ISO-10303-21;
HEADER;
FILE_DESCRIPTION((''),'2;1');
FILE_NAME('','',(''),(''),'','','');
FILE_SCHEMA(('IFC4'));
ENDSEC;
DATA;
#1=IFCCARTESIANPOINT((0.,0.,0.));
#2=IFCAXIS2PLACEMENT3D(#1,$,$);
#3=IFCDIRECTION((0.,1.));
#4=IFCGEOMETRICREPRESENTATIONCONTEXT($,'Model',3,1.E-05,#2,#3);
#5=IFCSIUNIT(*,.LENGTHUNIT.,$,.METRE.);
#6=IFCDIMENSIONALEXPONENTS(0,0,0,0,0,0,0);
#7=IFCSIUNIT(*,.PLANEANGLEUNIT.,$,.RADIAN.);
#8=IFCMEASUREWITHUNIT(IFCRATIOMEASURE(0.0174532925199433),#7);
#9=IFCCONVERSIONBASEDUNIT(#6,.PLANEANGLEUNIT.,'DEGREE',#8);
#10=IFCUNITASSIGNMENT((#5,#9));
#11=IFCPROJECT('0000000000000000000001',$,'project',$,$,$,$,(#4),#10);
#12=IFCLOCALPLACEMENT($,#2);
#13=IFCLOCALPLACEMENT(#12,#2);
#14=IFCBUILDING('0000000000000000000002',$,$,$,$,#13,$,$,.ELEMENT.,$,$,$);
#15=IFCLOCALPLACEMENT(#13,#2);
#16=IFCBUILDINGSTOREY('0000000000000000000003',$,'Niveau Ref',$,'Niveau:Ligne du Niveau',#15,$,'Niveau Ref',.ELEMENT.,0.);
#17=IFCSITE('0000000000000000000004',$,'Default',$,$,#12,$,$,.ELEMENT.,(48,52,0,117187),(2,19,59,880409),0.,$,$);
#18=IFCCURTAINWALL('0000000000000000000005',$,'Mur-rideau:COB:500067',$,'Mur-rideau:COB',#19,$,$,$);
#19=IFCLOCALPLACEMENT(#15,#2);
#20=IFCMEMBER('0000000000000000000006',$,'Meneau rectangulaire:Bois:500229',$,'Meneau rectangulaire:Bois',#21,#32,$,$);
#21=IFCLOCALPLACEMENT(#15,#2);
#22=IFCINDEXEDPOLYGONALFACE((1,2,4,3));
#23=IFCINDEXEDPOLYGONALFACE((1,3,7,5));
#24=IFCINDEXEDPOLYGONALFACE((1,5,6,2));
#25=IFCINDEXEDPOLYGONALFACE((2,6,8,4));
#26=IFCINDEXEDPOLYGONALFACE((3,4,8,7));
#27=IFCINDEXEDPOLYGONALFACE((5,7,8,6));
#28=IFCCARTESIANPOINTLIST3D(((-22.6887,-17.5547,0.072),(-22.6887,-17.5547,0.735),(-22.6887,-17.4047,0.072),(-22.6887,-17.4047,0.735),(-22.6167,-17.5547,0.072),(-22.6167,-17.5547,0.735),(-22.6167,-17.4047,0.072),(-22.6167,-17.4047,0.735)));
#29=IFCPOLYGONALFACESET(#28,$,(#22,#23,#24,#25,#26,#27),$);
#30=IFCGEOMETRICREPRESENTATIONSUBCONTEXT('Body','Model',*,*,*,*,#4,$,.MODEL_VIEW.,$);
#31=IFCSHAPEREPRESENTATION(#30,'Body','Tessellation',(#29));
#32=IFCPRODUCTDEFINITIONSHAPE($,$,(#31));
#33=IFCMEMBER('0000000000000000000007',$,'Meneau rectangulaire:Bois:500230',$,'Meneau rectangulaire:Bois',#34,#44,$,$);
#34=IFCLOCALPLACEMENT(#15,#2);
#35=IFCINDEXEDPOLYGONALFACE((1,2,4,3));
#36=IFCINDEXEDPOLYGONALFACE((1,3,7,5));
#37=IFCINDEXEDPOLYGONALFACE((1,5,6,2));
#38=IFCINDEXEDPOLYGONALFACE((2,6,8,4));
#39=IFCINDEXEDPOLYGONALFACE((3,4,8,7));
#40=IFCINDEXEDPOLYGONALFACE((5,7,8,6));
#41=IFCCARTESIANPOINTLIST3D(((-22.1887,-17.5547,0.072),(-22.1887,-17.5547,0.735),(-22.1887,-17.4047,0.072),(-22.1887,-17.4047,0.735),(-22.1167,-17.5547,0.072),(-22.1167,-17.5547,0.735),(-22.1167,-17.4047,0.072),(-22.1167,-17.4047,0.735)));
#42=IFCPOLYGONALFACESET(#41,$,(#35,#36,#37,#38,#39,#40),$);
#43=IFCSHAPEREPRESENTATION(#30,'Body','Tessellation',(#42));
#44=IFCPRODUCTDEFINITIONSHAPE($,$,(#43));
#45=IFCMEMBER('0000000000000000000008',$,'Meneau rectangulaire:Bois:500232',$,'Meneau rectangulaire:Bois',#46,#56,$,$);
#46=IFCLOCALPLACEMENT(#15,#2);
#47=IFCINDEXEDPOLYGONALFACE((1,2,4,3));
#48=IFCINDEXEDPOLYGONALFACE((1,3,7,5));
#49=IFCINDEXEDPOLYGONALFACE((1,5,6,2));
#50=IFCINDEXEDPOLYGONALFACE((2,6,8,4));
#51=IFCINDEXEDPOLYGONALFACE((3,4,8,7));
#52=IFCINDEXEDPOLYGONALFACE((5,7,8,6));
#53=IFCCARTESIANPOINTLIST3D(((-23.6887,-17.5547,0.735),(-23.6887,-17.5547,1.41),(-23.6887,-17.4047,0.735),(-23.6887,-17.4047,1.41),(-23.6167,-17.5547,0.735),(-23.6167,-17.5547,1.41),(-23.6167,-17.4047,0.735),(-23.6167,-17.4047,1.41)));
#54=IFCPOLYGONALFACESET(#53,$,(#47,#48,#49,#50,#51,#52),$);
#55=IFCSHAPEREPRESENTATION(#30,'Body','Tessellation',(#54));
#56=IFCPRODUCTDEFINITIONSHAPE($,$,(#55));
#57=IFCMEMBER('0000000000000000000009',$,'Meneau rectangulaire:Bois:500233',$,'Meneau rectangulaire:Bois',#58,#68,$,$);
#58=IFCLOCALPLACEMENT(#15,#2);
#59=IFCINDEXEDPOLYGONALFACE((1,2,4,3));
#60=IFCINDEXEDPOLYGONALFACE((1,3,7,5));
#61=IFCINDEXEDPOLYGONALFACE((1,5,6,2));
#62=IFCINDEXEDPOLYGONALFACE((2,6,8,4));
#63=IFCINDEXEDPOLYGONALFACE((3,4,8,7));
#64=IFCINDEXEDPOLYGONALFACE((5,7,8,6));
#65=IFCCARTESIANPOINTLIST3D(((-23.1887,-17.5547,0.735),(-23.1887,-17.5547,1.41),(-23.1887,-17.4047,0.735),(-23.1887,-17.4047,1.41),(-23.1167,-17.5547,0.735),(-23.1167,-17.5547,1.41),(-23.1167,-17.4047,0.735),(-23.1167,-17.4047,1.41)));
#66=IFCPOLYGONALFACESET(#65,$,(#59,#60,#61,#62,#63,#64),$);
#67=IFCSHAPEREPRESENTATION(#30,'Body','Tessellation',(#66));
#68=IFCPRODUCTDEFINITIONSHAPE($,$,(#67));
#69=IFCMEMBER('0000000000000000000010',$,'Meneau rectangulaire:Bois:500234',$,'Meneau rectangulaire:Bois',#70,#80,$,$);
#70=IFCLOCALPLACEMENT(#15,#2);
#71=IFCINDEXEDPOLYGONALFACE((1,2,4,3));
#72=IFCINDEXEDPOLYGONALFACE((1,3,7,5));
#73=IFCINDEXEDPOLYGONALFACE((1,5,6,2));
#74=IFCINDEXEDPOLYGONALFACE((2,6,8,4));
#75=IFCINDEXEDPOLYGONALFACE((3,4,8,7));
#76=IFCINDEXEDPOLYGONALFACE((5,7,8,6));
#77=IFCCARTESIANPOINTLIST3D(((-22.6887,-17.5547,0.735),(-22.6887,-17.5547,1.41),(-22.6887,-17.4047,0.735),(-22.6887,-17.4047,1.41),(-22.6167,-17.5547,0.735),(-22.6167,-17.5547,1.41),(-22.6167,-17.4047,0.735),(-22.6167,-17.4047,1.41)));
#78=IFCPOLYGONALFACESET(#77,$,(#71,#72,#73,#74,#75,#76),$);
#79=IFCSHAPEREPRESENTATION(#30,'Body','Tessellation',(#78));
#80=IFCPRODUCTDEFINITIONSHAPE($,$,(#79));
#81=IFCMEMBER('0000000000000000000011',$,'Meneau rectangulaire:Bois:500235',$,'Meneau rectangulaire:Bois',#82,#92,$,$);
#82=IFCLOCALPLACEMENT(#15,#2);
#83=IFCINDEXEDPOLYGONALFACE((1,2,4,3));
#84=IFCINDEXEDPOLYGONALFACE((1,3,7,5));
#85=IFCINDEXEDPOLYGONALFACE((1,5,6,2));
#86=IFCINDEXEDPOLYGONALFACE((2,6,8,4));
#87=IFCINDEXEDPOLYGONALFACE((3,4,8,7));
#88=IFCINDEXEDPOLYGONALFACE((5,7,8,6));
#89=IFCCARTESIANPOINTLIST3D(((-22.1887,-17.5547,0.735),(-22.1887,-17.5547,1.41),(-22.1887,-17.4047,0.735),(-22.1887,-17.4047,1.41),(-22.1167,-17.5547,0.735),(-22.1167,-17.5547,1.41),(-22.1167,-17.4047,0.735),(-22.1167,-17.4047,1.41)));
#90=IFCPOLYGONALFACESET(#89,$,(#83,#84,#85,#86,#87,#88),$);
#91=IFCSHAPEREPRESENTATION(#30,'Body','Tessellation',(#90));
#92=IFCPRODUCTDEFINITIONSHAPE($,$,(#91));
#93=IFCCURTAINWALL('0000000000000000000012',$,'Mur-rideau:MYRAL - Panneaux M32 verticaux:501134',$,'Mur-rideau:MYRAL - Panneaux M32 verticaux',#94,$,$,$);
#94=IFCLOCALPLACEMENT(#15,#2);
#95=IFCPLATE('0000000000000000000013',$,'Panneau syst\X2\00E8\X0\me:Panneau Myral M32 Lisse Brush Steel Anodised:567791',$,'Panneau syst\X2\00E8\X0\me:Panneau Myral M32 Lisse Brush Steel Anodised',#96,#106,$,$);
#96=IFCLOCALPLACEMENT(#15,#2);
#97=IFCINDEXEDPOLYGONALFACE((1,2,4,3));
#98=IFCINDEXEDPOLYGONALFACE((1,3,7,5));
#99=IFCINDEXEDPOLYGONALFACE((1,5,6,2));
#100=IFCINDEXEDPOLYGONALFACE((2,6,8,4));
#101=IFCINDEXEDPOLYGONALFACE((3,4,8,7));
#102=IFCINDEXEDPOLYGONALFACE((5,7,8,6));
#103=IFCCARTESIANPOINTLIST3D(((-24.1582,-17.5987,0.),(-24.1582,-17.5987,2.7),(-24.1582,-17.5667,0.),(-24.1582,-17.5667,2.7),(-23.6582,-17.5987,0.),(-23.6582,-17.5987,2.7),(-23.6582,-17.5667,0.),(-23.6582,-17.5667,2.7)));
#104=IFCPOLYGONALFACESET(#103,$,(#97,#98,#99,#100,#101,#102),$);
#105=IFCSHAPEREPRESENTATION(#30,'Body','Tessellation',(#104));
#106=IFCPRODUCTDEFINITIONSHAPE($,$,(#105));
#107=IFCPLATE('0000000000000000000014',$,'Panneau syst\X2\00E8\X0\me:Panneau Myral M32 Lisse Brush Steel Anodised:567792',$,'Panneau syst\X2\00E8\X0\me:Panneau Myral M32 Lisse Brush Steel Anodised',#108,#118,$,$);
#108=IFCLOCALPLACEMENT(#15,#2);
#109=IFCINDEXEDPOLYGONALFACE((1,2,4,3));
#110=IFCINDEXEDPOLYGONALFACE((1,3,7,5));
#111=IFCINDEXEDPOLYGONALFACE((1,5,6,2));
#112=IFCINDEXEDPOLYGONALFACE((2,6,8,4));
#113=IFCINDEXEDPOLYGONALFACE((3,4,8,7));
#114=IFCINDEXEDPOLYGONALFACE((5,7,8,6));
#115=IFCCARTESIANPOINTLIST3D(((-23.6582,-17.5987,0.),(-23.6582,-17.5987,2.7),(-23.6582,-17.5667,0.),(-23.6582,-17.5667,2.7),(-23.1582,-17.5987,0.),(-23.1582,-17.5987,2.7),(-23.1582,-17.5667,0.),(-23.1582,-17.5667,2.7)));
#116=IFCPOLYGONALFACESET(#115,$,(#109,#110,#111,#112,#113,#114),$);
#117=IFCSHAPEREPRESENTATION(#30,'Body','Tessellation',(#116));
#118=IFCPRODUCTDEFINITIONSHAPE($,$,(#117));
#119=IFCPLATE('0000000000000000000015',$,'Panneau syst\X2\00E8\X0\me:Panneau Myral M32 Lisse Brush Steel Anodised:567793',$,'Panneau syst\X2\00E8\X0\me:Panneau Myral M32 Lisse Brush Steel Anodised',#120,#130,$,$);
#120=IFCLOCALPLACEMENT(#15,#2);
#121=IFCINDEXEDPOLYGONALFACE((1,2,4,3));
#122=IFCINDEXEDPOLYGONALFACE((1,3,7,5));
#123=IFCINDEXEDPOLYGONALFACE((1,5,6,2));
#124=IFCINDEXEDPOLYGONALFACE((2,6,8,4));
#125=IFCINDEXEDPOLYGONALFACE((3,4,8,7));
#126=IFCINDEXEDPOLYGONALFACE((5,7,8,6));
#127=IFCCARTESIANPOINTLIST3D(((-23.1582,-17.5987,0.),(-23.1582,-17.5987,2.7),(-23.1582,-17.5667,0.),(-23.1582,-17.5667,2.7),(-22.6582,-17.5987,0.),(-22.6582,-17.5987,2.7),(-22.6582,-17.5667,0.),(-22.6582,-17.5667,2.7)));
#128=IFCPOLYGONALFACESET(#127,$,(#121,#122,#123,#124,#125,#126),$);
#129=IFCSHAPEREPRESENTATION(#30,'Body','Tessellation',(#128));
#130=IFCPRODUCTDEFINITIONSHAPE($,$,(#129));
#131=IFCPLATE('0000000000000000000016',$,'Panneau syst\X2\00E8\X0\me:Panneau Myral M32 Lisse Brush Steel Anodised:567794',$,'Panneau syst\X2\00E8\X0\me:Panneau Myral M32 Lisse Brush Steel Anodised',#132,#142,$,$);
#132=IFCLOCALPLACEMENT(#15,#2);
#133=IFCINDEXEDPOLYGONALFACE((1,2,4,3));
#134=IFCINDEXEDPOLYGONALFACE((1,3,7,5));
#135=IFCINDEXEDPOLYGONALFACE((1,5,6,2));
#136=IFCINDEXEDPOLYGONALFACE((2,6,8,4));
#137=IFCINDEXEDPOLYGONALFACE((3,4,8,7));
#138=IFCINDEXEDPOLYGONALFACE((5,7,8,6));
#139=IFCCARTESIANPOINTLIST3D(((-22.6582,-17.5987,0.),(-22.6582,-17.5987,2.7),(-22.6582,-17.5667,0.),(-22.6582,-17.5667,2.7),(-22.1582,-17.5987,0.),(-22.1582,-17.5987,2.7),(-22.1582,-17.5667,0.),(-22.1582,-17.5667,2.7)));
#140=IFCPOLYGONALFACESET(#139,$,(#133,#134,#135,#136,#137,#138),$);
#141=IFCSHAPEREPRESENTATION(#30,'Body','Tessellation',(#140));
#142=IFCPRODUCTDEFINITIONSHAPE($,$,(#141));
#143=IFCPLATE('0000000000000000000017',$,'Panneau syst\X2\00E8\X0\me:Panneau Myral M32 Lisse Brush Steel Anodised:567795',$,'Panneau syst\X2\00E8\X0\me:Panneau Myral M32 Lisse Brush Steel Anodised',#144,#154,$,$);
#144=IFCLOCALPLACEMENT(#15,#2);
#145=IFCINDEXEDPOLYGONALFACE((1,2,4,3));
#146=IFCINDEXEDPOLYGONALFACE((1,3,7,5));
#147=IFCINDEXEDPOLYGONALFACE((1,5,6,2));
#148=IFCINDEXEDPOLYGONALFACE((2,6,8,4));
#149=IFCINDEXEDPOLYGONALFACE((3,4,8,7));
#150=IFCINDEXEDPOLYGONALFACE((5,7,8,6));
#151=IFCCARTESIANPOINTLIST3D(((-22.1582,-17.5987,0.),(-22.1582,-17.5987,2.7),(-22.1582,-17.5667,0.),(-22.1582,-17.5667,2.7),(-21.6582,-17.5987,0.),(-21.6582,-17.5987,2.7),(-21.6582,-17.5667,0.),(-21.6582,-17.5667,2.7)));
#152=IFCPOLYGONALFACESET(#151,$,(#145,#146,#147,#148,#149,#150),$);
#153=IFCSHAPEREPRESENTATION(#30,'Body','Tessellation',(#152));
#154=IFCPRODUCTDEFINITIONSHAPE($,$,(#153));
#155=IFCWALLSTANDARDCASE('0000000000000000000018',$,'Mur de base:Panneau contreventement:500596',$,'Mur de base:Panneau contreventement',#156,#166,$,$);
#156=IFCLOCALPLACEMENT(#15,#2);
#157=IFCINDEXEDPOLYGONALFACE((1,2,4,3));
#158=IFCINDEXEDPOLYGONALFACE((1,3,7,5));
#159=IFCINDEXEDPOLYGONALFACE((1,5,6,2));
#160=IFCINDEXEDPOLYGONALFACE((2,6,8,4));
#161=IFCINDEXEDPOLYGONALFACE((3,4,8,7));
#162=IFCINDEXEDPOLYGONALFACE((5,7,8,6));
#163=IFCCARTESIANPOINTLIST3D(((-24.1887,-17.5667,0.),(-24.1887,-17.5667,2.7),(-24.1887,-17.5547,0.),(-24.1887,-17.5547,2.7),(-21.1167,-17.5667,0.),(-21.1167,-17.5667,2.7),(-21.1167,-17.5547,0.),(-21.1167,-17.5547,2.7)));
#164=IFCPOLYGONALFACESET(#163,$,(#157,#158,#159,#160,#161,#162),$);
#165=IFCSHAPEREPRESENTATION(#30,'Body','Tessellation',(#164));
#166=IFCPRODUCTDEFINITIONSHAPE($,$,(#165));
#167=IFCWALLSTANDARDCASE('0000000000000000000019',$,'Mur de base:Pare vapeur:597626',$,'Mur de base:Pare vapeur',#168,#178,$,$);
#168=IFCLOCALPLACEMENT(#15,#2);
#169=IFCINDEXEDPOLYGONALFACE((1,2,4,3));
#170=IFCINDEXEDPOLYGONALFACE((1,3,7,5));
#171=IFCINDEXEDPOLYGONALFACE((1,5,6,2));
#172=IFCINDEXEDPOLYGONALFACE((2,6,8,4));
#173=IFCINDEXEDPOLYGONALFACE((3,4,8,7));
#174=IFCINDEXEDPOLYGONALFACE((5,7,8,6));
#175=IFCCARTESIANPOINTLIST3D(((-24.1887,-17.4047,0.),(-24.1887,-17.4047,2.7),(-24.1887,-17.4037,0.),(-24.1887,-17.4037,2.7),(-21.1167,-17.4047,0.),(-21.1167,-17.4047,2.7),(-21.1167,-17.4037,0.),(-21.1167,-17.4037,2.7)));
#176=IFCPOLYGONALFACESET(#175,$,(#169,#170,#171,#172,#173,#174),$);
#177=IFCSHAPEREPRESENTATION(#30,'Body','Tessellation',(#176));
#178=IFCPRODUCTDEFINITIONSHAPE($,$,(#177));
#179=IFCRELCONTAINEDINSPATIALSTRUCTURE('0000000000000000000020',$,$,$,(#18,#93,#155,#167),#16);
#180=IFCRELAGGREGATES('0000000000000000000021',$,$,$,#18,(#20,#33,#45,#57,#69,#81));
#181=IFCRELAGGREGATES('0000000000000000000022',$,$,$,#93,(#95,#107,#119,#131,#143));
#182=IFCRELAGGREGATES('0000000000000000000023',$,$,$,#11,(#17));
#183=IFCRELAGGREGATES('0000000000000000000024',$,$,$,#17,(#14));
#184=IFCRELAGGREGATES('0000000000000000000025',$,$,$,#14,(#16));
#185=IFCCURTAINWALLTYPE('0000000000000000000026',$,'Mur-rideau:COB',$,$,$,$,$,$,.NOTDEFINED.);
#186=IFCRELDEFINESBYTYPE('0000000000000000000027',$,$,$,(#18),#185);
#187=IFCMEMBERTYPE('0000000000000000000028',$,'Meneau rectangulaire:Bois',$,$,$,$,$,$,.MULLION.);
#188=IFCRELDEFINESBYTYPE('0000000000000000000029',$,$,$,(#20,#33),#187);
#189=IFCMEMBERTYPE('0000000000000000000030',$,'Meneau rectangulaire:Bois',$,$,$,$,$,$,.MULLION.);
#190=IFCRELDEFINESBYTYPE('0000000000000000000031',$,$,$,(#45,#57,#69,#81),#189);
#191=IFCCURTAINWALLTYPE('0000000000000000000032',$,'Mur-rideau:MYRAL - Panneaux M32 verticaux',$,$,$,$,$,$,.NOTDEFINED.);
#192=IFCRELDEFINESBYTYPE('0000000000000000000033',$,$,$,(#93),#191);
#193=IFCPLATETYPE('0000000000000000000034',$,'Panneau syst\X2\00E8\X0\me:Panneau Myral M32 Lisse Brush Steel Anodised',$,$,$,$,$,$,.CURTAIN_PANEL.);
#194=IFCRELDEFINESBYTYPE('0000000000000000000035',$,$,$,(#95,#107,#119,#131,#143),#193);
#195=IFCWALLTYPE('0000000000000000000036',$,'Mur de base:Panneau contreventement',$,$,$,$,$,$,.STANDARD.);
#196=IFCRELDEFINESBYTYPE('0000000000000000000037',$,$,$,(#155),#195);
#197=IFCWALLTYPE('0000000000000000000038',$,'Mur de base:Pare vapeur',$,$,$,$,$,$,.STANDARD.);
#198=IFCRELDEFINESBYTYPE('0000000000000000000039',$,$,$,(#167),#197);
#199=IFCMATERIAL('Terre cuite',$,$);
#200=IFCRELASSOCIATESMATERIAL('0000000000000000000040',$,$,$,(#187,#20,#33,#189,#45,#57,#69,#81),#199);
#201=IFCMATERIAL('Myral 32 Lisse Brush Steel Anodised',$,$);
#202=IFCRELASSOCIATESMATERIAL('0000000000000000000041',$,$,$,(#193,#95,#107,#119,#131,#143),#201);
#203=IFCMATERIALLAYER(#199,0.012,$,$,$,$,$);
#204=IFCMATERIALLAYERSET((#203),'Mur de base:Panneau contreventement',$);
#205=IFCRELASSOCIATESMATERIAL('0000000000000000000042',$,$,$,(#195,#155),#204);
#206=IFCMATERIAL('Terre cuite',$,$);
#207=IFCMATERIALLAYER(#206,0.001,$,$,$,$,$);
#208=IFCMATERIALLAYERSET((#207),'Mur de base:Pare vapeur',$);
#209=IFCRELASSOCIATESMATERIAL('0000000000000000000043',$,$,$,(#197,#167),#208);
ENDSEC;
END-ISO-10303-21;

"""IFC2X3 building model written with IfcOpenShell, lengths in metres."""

from ifc_helpers import new_model, entity, si_unit, converted_unit, direction, frame, frame_2d, origin, origin_2d_with_axis, place, context, subcontext, project, spatial, rectangle, extrude, source, transform, mapped, material, layer, layer_set, layer_usage, type_object, type_shapes, element, aggregate, save


model = new_model("IFC2X3")

# Units and contexts
model_context = context("Model", 3, precision=1e-05, world=origin(), true_north=direction((0.0, 1.0)))
body_context = subcontext(model_context, "Body", "Model", "MODEL_VIEW")
ifc_project = project(units=[si_unit("LENGTHUNIT", "METRE"), converted_unit("PLANEANGLEUNIT", "DEGREE", entity("IfcRatioMeasure", 0.0174532925199433), si_unit("PLANEANGLEUNIT", "RADIAN"), dimensions=[0, 0, 0, 0, 0, 0, 0])], contexts=[model_context])

# Site, building, storey
site_placement = place(None, origin())
site = spatial("IfcSite", under=ifc_project, at=site_placement, Name="Default", CompositionType="ELEMENT", RefLatitude=(48, 52, 0, 117187), RefLongitude=(2, 19, 59, 880409), RefElevation=0.0)
building_placement = place(site_placement, origin())
building = spatial("IfcBuilding", under=site, at=building_placement, CompositionType="ELEMENT")
storey_placement = place(building_placement, origin())
storey = spatial("IfcBuildingStorey", under=building, at=storey_placement, Name="Niveau Ref", ObjectType="Niveau:Ligne du Niveau", LongName="Niveau Ref", CompositionType="ELEMENT", Elevation=0.0)

# Curtain wall, members
curtain_wall_type_1 = type_object("IfcCurtainWallType", Name="Mur-rideau:COB", PredefinedType="NOTDEFINED")
curtain_wall_1_placement = place(storey_placement, origin())
curtain_wall_1 = element("IfcCurtainWall", 1, at=curtain_wall_1_placement, inside=storey, type_object=curtain_wall_type_1, Name="Mur-rideau:COB:500067", ObjectType="Mur-rideau:COB")
ifc_material_1 = material(Name="Terre cuite")
member_type_1 = type_object("IfcMemberType", Name="Meneau rectangulaire:Bois", PredefinedType="MULLION", material=ifc_material_1)
shared_shape_1 = source(origin(), body_context, "Body", "SweptSolid", [
    extrude(rectangle(XDim=0.15, YDim=0.072, at=origin_2d_with_axis()), frame((-0.024, 0.0, -0.663), z_axis=(0.0, 0.0, 1.0), x_axis=(0.0, -1.0, 0.0)), (0.0, 0.0, 1.0), 0.663),
])
type_shapes(member_type_1, [shared_shape_1])
member_1_placement = place(storey_placement, frame((-22.6287, -17.4797, 0.072), z_axis=(0.0, 0.0, -1.0), x_axis=(1.0, 0.0, 0.0)))
member_1 = element("IfcMember", 2, at=member_1_placement, type_object=member_type_1, material=ifc_material_1, Name="Meneau rectangulaire:Bois:500229", ObjectType="Meneau rectangulaire:Bois", context=body_context, shape_type="MappedRepresentation", body=[
    mapped(shared_shape_1, transform((0.0, 0.0, 0.0), scale=1.0)),
])
member_2_placement = place(storey_placement, frame((-22.1287, -17.4797, 0.072), z_axis=(0.0, 0.0, -1.0), x_axis=(1.0, 0.0, 0.0)))
member_2 = element("IfcMember", 3, at=member_2_placement, type_object=member_type_1, material=ifc_material_1, Name="Meneau rectangulaire:Bois:500230", ObjectType="Meneau rectangulaire:Bois", context=body_context, shape_type="MappedRepresentation", body=[
    mapped(shared_shape_1, transform((0.0, 0.0, 0.0), scale=1.0)),
])
member_type_2 = type_object("IfcMemberType", Name="Meneau rectangulaire:Bois", PredefinedType="MULLION", material=ifc_material_1)
shared_shape_2 = source(origin(), body_context, "Body", "SweptSolid", [
    extrude(rectangle(XDim=0.15, YDim=0.072, at=origin_2d_with_axis()), frame((-0.024, 0.0, -0.675), z_axis=(0.0, 0.0, 1.0), x_axis=(0.0, -1.0, 0.0)), (0.0, 0.0, 1.0), 0.675),
])
type_shapes(member_type_2, [shared_shape_2])
member_3_placement = place(storey_placement, frame((-23.6287, -17.4797, 0.735), z_axis=(0.0, 0.0, -1.0), x_axis=(1.0, 0.0, 0.0)))
member_3 = element("IfcMember", 4, at=member_3_placement, type_object=member_type_2, material=ifc_material_1, Name="Meneau rectangulaire:Bois:500232", ObjectType="Meneau rectangulaire:Bois", context=body_context, shape_type="MappedRepresentation", body=[
    mapped(shared_shape_2, transform((0.0, 0.0, 0.0), scale=1.0)),
])
member_4_placement = place(storey_placement, frame((-23.1287, -17.4797, 0.735), z_axis=(0.0, 0.0, -1.0), x_axis=(1.0, 0.0, 0.0)))
member_4 = element("IfcMember", 5, at=member_4_placement, type_object=member_type_2, material=ifc_material_1, Name="Meneau rectangulaire:Bois:500233", ObjectType="Meneau rectangulaire:Bois", context=body_context, shape_type="MappedRepresentation", body=[
    mapped(shared_shape_2, transform((0.0, 0.0, 0.0), scale=1.0)),
])
member_5_placement = place(storey_placement, frame((-22.6287, -17.4797, 0.735), z_axis=(0.0, 0.0, -1.0), x_axis=(1.0, 0.0, 0.0)))
member_5 = element("IfcMember", 6, at=member_5_placement, type_object=member_type_2, material=ifc_material_1, Name="Meneau rectangulaire:Bois:500234", ObjectType="Meneau rectangulaire:Bois", context=body_context, shape_type="MappedRepresentation", body=[
    mapped(shared_shape_2, transform((0.0, 0.0, 0.0), scale=1.0)),
])
member_6_placement = place(storey_placement, frame((-22.1287, -17.4797, 0.735), z_axis=(0.0, 0.0, -1.0), x_axis=(1.0, 0.0, 0.0)))
member_6 = element("IfcMember", 7, at=member_6_placement, type_object=member_type_2, material=ifc_material_1, Name="Meneau rectangulaire:Bois:500235", ObjectType="Meneau rectangulaire:Bois", context=body_context, shape_type="MappedRepresentation", body=[
    mapped(shared_shape_2, transform((0.0, 0.0, 0.0), scale=1.0)),
])
aggregate(curtain_wall_1, [member_1, member_2, member_3, member_4, member_5, member_6])

# Curtain wall, plates
curtain_wall_type_2 = type_object("IfcCurtainWallType", Name="Mur-rideau:MYRAL - Panneaux M32 verticaux", PredefinedType="NOTDEFINED")
curtain_wall_2_placement = place(storey_placement, origin())
curtain_wall_2 = element("IfcCurtainWall", 8, at=curtain_wall_2_placement, inside=storey, type_object=curtain_wall_type_2, Name="Mur-rideau:MYRAL - Panneaux M32 verticaux:501134", ObjectType="Mur-rideau:MYRAL - Panneaux M32 verticaux")
ifc_material_2 = material(Name="Myral 32 Lisse Brush Steel Anodised")
plate_type = type_object("IfcPlateType", Name="Panneau système:Panneau Myral M32 Lisse Brush Steel Anodised", PredefinedType="CURTAIN_PANEL", material=ifc_material_2)
shared_shape_3 = source(origin(), body_context, "Body", "SweptSolid", [
    extrude(rectangle(XDim=0.032, YDim=0.5, at=origin_2d_with_axis()), frame((0.0, -0.016, 0.0), z_axis=(0.0, 0.0, 1.0), x_axis=(0.0, 1.0, 0.0)), (0.0, 0.0, 1.0), 2.7),
])
type_shapes(plate_type, [shared_shape_3])
plate_1_placement = place(curtain_wall_2_placement, frame((-23.9082, -17.5667, 0.0)))
plate_1 = element("IfcPlate", 9, at=plate_1_placement, type_object=plate_type, material=ifc_material_2, Name="Panneau système:Panneau Myral M32 Lisse Brush Steel Anodised:567791", ObjectType="Panneau système:Panneau Myral M32 Lisse Brush Steel Anodised", context=body_context, shape_type="MappedRepresentation", body=[
    mapped(shared_shape_3, transform((0.0, 0.0, 0.0), scale=1.0)),
])
plate_2_placement = place(curtain_wall_2_placement, frame((-23.4082, -17.5667, 0.0)))
plate_2 = element("IfcPlate", 10, at=plate_2_placement, type_object=plate_type, material=ifc_material_2, Name="Panneau système:Panneau Myral M32 Lisse Brush Steel Anodised:567792", ObjectType="Panneau système:Panneau Myral M32 Lisse Brush Steel Anodised", context=body_context, shape_type="MappedRepresentation", body=[
    mapped(shared_shape_3, transform((0.0, 0.0, 0.0), scale=1.0)),
])
plate_3_placement = place(curtain_wall_2_placement, frame((-22.9082, -17.5667, 0.0)))
plate_3 = element("IfcPlate", 11, at=plate_3_placement, type_object=plate_type, material=ifc_material_2, Name="Panneau système:Panneau Myral M32 Lisse Brush Steel Anodised:567793", ObjectType="Panneau système:Panneau Myral M32 Lisse Brush Steel Anodised", context=body_context, shape_type="MappedRepresentation", body=[
    mapped(shared_shape_3, transform((0.0, 0.0, 0.0), scale=1.0)),
])
plate_4_placement = place(curtain_wall_2_placement, frame((-22.4082, -17.5667, 0.0)))
plate_4 = element("IfcPlate", 12, at=plate_4_placement, type_object=plate_type, material=ifc_material_2, Name="Panneau système:Panneau Myral M32 Lisse Brush Steel Anodised:567794", ObjectType="Panneau système:Panneau Myral M32 Lisse Brush Steel Anodised", context=body_context, shape_type="MappedRepresentation", body=[
    mapped(shared_shape_3, transform((0.0, 0.0, 0.0), scale=1.0)),
])
plate_5_placement = place(curtain_wall_2_placement, frame((-21.9082, -17.5667, 0.0)))
plate_5 = element("IfcPlate", 13, at=plate_5_placement, type_object=plate_type, material=ifc_material_2, Name="Panneau système:Panneau Myral M32 Lisse Brush Steel Anodised:567795", ObjectType="Panneau système:Panneau Myral M32 Lisse Brush Steel Anodised", context=body_context, shape_type="MappedRepresentation", body=[
    mapped(shared_shape_3, transform((0.0, 0.0, 0.0), scale=1.0)),
])
aggregate(curtain_wall_2, [plate_1, plate_2, plate_3, plate_4, plate_5])

# Walls
ifc_layer_1 = layer(ifc_material_1, 0.012)
ifc_layer_set_1 = layer_set([ifc_layer_1], Name="Mur de base:Panneau contreventement")
ifc_layer_usage_1 = layer_usage(ifc_layer_set_1, "AXIS2", "NEGATIVE", 0.006)
wall_type_1 = type_object("IfcWallType", Name="Mur de base:Panneau contreventement", PredefinedType="STANDARD", material=ifc_layer_set_1)
wall_1_placement = place(storey_placement, frame((-24.1887, -17.5607, 0.0)))
element("IfcWallStandardCase", 14, at=wall_1_placement, inside=storey, type_object=wall_type_1, material=ifc_layer_usage_1, Name="Mur de base:Panneau contreventement:500596", ObjectType="Mur de base:Panneau contreventement", context=body_context, shape_type="SweptSolid", body=[
    extrude(rectangle(XDim=3.072, YDim=0.012, at=frame_2d((1.536, 0.0), x_axis=(-1.0, 0.0))), origin(), (0.0, 0.0, 1.0), 2.7),
])
ifc_material_3 = material(Name="Terre cuite")
ifc_layer_2 = layer(ifc_material_3, 0.001)
ifc_layer_set_2 = layer_set([ifc_layer_2], Name="Mur de base:Pare vapeur")
ifc_layer_usage_2 = layer_usage(ifc_layer_set_2, "AXIS2", "NEGATIVE", 0.0005)
wall_type_2 = type_object("IfcWallType", Name="Mur de base:Pare vapeur", PredefinedType="STANDARD", material=ifc_layer_set_2)
wall_2_placement = place(storey_placement, frame((-24.1887, -17.4042, 0.0)))
element("IfcWallStandardCase", 15, at=wall_2_placement, inside=storey, type_object=wall_type_2, material=ifc_layer_usage_2, Name="Mur de base:Pare vapeur:597626", ObjectType="Mur de base:Pare vapeur", context=body_context, shape_type="SweptSolid", body=[
    extrude(rectangle(XDim=3.072, YDim=0.001, at=frame_2d((1.536, 0.0), x_axis=(-1.0, 0.0))), origin(), (0.0, 0.0, 1.0), 2.7),
])

save(model, "model.ifc")
